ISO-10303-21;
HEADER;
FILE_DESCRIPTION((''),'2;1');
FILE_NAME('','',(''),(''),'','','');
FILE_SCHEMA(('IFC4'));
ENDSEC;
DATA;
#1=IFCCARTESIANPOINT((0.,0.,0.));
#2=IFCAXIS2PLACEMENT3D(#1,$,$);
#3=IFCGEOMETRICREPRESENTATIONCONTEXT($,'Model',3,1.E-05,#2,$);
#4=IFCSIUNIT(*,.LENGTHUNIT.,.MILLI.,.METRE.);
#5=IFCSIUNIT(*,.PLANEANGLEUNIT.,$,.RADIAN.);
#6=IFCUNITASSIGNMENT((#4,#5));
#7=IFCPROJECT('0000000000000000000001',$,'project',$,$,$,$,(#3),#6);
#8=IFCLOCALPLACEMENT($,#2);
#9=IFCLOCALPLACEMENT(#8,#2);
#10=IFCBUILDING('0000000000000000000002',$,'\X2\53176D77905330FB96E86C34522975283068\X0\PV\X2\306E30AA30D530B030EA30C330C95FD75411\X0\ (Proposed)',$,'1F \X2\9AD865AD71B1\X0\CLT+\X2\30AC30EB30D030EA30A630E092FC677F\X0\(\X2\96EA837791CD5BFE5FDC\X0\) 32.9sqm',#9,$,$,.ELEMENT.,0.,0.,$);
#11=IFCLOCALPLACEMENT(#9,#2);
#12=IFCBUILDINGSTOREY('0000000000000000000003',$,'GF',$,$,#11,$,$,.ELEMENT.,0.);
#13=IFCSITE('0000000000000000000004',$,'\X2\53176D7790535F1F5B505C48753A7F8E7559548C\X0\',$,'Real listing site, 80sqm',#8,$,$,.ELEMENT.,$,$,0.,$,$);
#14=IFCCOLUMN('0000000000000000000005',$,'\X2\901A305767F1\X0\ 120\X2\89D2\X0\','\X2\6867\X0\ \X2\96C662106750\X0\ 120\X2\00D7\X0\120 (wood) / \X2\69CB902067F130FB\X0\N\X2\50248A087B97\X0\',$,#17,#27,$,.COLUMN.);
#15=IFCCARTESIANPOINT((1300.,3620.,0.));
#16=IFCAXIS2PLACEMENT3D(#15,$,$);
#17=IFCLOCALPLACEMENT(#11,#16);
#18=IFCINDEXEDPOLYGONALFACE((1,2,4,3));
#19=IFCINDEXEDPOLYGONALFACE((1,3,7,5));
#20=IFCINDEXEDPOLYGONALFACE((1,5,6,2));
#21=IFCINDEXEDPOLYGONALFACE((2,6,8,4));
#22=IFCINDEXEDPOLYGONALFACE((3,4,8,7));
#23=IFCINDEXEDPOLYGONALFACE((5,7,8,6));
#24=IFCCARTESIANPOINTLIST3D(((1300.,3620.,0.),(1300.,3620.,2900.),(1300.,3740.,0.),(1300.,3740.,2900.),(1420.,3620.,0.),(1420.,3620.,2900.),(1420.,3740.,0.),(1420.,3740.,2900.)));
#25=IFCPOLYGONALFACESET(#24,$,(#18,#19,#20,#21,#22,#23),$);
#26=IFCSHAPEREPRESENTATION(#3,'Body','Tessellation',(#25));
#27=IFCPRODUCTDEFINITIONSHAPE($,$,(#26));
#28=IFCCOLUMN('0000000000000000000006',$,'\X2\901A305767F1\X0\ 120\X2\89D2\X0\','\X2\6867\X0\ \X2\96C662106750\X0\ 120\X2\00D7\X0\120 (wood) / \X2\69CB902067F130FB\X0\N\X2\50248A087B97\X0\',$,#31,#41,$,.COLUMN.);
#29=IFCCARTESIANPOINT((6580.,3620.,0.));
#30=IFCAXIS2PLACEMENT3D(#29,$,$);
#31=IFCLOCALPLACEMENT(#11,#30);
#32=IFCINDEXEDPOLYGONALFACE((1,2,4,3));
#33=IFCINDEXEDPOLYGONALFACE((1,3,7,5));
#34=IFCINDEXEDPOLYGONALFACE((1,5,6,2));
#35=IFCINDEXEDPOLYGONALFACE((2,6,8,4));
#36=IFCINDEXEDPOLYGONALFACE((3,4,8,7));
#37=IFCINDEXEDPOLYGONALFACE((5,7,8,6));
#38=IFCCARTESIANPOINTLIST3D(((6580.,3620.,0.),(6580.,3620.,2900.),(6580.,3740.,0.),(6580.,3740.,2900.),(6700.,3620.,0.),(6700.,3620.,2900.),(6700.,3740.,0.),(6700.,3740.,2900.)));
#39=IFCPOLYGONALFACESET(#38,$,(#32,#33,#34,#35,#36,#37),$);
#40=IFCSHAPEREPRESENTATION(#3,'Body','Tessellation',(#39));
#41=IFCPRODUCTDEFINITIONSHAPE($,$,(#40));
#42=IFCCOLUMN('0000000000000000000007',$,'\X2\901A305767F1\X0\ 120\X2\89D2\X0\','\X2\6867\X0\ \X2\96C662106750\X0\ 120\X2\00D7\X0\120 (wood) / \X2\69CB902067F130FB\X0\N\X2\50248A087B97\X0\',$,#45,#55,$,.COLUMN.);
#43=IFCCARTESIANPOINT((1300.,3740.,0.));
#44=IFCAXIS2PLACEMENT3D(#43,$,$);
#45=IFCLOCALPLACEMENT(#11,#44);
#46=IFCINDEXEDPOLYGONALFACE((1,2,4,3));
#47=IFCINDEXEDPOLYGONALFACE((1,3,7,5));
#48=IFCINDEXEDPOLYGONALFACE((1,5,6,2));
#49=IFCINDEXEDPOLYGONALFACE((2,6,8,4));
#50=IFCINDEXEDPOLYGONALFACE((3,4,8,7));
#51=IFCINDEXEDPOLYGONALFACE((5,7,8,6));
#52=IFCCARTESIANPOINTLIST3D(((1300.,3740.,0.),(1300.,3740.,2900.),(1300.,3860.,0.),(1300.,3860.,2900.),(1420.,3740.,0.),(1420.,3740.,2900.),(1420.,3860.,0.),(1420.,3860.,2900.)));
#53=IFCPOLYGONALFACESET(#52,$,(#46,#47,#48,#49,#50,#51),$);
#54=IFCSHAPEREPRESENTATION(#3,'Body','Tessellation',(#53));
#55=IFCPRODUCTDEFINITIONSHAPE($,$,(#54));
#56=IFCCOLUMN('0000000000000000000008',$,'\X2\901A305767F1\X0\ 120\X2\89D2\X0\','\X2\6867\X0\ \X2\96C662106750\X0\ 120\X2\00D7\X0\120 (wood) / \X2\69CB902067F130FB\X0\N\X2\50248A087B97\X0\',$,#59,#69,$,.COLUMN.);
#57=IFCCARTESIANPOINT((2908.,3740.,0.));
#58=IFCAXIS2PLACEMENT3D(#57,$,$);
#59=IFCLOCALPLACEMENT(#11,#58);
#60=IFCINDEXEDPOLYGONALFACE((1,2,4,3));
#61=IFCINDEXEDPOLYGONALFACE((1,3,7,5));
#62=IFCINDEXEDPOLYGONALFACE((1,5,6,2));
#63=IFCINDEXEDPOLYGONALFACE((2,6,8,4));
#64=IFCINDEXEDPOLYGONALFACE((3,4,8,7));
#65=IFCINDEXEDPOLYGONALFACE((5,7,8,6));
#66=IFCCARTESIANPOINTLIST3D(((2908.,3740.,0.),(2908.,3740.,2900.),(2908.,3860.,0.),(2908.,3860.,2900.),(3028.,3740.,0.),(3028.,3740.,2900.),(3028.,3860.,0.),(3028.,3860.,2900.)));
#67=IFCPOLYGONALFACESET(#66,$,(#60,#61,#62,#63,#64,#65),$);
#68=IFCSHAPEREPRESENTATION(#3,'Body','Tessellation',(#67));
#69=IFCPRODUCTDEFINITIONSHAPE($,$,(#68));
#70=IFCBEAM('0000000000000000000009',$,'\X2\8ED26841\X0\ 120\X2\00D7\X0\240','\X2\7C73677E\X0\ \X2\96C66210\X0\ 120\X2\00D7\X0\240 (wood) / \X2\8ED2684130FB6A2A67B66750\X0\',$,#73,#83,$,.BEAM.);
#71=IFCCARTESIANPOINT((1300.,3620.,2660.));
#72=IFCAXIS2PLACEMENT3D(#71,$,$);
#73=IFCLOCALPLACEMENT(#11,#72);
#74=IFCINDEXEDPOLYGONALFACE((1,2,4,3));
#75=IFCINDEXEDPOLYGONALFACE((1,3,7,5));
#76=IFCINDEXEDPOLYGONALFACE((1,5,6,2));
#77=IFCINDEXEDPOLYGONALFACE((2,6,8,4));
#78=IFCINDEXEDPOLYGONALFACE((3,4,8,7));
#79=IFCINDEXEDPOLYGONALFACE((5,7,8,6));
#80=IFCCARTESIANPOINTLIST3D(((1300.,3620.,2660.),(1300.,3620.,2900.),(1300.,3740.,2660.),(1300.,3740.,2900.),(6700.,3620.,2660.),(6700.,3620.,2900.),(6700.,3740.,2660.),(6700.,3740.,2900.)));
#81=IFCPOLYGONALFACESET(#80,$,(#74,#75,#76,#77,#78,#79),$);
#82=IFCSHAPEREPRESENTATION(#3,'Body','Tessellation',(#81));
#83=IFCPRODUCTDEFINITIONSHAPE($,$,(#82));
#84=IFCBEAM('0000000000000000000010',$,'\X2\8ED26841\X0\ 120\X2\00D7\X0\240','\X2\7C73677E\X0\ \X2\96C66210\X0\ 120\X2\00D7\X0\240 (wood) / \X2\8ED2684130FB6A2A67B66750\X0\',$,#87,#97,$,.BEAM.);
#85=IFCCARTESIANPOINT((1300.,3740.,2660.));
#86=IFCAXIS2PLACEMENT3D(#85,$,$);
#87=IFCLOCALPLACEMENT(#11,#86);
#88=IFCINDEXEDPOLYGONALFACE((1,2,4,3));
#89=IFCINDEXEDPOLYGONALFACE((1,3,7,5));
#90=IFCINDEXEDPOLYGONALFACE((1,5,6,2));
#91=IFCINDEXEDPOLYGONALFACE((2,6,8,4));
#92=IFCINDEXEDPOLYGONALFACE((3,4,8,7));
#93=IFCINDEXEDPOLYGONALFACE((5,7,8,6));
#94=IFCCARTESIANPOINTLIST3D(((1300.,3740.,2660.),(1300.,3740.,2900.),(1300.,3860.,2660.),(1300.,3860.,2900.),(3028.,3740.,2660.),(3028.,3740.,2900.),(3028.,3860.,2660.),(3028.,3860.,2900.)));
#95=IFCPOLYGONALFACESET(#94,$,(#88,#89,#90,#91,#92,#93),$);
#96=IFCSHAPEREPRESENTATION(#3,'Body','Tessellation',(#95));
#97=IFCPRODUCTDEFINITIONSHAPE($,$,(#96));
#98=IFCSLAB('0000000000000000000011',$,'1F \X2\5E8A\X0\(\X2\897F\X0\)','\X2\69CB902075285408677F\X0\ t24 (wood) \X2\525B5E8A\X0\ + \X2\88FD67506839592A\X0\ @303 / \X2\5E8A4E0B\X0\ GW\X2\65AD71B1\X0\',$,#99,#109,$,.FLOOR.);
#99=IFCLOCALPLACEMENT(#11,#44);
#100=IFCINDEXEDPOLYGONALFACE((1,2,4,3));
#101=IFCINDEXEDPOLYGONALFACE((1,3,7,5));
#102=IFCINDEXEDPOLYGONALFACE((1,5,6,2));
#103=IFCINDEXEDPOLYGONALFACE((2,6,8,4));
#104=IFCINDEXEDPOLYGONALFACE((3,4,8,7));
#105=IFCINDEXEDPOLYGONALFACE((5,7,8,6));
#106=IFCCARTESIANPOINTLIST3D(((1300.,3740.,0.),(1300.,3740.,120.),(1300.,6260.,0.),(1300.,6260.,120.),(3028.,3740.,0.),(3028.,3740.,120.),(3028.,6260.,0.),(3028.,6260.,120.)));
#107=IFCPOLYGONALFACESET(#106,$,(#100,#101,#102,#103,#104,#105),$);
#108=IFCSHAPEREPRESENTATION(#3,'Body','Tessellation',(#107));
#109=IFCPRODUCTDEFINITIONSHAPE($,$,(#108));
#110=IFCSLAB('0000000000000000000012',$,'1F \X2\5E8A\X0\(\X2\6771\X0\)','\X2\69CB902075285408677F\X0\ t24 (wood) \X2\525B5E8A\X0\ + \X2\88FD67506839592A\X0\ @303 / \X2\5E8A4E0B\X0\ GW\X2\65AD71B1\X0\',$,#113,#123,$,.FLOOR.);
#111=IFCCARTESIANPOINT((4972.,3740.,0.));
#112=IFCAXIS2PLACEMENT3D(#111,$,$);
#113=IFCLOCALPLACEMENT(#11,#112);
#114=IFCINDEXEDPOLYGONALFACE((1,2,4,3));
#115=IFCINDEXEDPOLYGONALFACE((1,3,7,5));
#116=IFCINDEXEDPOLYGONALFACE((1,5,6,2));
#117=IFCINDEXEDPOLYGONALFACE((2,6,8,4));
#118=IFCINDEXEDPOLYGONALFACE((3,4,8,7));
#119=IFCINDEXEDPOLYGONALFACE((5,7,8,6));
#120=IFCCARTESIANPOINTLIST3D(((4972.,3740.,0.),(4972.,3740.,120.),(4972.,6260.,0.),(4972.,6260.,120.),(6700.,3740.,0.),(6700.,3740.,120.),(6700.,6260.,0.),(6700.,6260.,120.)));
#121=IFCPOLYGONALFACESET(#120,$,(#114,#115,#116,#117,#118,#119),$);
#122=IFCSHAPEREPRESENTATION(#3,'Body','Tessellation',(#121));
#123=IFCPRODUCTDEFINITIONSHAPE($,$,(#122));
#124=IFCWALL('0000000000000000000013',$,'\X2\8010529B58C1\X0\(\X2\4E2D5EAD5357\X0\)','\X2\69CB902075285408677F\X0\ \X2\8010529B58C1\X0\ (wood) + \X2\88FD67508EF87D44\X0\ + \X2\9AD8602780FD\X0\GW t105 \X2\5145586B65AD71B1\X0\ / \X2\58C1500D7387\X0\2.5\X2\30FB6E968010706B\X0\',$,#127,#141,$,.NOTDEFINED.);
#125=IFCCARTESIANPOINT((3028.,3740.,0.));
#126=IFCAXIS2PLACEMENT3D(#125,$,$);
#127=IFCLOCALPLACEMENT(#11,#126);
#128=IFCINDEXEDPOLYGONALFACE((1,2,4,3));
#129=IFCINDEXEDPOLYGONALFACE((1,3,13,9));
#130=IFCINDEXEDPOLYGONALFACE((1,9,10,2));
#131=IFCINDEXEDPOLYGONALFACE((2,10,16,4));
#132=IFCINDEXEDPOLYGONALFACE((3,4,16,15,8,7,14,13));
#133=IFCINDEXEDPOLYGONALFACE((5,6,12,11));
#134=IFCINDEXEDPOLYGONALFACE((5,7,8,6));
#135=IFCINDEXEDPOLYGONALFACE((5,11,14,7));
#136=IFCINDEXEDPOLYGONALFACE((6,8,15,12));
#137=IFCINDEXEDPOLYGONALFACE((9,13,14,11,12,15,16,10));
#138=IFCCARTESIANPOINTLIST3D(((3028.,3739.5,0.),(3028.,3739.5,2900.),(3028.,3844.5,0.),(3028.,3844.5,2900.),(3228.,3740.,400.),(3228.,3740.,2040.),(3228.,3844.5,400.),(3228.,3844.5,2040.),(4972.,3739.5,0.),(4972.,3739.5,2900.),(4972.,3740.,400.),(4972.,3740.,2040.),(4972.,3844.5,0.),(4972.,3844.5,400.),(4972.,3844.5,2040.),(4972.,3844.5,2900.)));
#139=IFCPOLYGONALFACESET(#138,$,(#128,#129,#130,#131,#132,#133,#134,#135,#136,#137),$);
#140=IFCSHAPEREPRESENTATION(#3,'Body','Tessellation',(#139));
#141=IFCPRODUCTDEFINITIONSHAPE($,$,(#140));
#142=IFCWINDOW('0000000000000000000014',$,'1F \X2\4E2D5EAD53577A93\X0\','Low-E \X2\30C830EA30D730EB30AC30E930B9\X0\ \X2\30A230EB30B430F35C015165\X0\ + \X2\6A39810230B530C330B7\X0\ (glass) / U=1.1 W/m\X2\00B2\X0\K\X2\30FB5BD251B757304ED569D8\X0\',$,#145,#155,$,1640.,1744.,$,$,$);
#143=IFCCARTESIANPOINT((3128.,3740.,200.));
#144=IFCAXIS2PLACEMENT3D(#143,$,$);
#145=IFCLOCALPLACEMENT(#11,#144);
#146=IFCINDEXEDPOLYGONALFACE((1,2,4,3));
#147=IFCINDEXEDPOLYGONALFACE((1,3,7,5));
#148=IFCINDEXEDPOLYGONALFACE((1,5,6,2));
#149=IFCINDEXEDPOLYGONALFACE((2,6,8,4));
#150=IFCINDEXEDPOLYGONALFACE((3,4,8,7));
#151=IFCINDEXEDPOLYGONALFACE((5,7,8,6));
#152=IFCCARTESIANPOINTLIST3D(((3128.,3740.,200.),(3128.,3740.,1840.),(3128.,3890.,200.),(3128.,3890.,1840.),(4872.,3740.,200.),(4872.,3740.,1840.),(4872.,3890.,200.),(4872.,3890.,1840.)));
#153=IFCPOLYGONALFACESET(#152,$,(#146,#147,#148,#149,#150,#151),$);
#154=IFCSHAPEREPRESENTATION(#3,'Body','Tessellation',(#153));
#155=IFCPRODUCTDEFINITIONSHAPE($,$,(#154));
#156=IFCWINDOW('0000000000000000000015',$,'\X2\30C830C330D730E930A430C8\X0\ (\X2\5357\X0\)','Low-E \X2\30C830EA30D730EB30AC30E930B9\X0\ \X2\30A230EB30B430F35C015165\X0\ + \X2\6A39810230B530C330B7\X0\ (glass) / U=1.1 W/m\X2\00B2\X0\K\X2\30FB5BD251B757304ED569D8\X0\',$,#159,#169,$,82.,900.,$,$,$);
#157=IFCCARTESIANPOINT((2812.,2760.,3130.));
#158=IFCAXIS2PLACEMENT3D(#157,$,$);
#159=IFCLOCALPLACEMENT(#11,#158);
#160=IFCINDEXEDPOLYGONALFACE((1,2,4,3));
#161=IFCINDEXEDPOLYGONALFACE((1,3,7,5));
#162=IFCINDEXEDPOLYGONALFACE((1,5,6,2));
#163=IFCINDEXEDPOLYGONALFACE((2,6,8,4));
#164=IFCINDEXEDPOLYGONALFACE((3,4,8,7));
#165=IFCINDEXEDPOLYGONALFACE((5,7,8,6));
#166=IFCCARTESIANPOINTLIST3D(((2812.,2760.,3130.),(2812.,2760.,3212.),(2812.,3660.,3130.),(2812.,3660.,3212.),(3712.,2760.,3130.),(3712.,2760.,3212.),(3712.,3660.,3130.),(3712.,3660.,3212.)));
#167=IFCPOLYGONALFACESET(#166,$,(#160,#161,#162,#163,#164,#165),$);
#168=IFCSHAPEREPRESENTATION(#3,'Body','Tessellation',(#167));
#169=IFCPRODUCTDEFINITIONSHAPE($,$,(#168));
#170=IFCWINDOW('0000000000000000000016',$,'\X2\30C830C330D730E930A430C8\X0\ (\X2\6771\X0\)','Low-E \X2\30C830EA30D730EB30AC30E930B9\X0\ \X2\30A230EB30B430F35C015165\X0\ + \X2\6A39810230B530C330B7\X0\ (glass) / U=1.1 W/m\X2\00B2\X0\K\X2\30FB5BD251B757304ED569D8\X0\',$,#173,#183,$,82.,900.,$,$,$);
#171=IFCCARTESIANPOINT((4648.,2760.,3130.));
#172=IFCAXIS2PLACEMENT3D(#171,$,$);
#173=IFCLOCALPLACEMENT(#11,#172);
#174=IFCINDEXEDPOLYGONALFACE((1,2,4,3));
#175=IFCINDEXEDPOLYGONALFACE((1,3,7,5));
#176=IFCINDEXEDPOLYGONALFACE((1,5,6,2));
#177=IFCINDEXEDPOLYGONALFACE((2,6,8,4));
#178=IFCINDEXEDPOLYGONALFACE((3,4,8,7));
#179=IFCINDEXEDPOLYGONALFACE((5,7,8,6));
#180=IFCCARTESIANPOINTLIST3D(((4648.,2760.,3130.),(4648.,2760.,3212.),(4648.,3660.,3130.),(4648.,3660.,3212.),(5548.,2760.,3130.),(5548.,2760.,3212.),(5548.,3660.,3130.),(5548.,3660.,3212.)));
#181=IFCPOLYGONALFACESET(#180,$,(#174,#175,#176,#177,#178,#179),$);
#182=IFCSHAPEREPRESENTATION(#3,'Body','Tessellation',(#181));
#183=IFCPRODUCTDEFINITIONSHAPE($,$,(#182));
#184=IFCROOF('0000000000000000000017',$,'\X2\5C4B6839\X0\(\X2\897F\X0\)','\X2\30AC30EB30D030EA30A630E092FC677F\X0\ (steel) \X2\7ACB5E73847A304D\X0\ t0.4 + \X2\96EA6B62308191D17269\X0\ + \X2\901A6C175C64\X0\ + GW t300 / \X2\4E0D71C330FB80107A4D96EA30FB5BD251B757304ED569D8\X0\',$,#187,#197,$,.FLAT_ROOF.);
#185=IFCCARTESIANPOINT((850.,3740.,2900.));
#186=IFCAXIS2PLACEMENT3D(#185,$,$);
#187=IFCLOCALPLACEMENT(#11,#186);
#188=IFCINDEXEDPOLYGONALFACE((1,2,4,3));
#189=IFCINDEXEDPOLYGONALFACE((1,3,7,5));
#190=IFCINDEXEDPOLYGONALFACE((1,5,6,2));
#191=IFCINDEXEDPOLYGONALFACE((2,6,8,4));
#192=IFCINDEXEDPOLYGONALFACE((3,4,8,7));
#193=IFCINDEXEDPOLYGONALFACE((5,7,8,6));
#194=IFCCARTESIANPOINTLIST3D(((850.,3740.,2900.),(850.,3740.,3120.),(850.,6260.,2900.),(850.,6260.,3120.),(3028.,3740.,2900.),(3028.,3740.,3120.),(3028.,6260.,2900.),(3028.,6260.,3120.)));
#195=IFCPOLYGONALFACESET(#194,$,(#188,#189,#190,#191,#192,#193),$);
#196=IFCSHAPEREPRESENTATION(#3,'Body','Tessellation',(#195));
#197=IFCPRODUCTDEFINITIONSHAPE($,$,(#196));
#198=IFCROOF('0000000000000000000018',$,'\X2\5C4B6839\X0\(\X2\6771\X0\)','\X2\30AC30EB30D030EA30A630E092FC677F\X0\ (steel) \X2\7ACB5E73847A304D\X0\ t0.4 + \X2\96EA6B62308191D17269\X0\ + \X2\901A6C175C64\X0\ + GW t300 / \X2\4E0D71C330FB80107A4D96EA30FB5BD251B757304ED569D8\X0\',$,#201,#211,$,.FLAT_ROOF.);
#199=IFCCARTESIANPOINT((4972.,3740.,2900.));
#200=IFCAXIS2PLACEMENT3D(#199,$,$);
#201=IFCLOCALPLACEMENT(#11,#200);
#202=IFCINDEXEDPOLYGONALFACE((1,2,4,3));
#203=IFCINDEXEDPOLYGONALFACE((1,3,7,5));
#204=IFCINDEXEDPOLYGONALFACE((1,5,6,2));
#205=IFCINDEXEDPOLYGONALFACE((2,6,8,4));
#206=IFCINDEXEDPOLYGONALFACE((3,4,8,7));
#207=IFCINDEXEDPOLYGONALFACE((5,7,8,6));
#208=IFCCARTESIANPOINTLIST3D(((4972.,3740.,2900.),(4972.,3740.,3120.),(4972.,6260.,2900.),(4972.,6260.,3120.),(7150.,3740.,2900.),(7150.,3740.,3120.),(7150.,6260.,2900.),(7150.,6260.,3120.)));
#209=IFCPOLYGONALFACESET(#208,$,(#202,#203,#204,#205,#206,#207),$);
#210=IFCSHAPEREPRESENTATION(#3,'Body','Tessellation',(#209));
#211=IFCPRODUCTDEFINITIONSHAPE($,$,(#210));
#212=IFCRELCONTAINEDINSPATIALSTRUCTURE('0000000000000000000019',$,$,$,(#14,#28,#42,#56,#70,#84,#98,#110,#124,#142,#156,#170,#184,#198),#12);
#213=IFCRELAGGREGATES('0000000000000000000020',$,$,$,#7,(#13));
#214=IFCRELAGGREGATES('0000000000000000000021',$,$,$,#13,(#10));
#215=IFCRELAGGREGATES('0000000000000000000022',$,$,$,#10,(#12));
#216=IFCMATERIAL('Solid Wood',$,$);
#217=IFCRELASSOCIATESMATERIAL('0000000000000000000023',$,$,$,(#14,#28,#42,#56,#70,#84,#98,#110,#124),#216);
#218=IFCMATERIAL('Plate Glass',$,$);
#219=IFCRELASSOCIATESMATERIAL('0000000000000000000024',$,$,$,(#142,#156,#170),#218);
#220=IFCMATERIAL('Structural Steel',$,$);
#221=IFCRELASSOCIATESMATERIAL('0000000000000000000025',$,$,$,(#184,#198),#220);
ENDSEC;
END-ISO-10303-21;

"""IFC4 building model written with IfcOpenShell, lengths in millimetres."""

from ifc_helpers import new_model, si_unit, frame, frame_2d, origin, place, context, project, spatial, rectangle, extrude, material, element, fill, save


model = new_model("IFC4")

# Units and contexts
model_context = context("Model", 3, precision=1e-05, world=origin())
ifc_project = project(units=[si_unit("LENGTHUNIT", "METRE", prefix="MILLI"), si_unit("PLANEANGLEUNIT", "RADIAN")], contexts=[model_context])

# Site, building, storey
site_placement = place(None, origin())
site = spatial("IfcSite", under=ifc_project, at=site_placement, Name="北海道弟子屈町美留和", ObjectType="Real listing site, 80sqm", CompositionType="ELEMENT", RefElevation=0.0)
building_placement = place(site_placement, origin())
building = spatial("IfcBuilding", under=site, at=building_placement, Name="北海道・雨水利用とPVのオフグリッド志向 (Proposed)", ObjectType="1F 高断熱CLT+ガルバリウム鋼板(雪荷重対応) 32.9sqm", CompositionType="ELEMENT", ElevationOfRefHeight=0.0, ElevationOfTerrain=0.0)
storey_placement = place(building_placement, origin())
storey = spatial("IfcBuildingStorey", under=building, at=storey_placement, Name="GF", CompositionType="ELEMENT", Elevation=0.0)

# Columns
ifc_material_1 = material(Name="Solid Wood")
column_1_placement = place(storey_placement, frame((1300.0, 3620.0, 0.0)))
element("IfcColumn", 1, at=column_1_placement, inside=storey, material=ifc_material_1, Name="通し柱 120角", Description="桧 集成材 120×120 (wood) / 構造柱・N値計算", PredefinedType="COLUMN", context=model_context, shape_type="SweptSolid", body=[
    extrude(rectangle(XDim=120.0, YDim=120.0, at=frame_2d((60.0, 60.0))), frame((1300.0, 3620.0, 0.0)), (0.0, 0.0, 1.0), 2900.0),
])
column_2_placement = place(storey_placement, frame((6580.0, 3620.0, 0.0)))
element("IfcColumn", 2, at=column_2_placement, inside=storey, material=ifc_material_1, Name="通し柱 120角", Description="桧 集成材 120×120 (wood) / 構造柱・N値計算", PredefinedType="COLUMN", context=model_context, shape_type="SweptSolid", body=[
    extrude(rectangle(XDim=120.0, YDim=120.0, at=frame_2d((60.0, 60.0))), frame((6580.0, 3620.0, 0.0)), (0.0, 0.0, 1.0), 2900.0),
])
column_3_placement = place(storey_placement, frame((1300.0, 3740.0, 0.0)))
element("IfcColumn", 3, at=column_3_placement, inside=storey, material=ifc_material_1, Name="通し柱 120角", Description="桧 集成材 120×120 (wood) / 構造柱・N値計算", PredefinedType="COLUMN", context=model_context, shape_type="SweptSolid", body=[
    extrude(rectangle(XDim=120.0, YDim=120.0, at=frame_2d((60.0, 60.0))), frame((1300.0, 3740.0, 0.0)), (0.0, 0.0, 1.0), 2900.0),
])
column_4_placement = place(storey_placement, frame((2908.0, 3740.0, 0.0)))
element("IfcColumn", 4, at=column_4_placement, inside=storey, material=ifc_material_1, Name="通し柱 120角", Description="桧 集成材 120×120 (wood) / 構造柱・N値計算", PredefinedType="COLUMN", context=model_context, shape_type="SweptSolid", body=[
    extrude(rectangle(XDim=120.0, YDim=120.0, at=frame_2d((60.0, 60.0))), frame((2908.0, 3740.0, 0.0)), (0.0, 0.0, 1.0), 2900.0),
])

# Beams
beam_1_placement = place(storey_placement, frame((1300.0, 3620.0, 2660.0)))
element("IfcBeam", 5, at=beam_1_placement, inside=storey, material=ifc_material_1, Name="軒桁 120×240", Description="米松 集成 120×240 (wood) / 軒桁・横架材", PredefinedType="BEAM", context=model_context, shape_type="SweptSolid", body=[
    extrude(rectangle(XDim=5400.0, YDim=120.0, at=frame_2d((2700.0, 60.0))), frame((1300.0, 3620.0, 2660.0)), (0.0, 0.0, 1.0), 240.0),
])
beam_2_placement = place(storey_placement, frame((1300.0, 3740.0, 2660.0)))
element("IfcBeam", 6, at=beam_2_placement, inside=storey, material=ifc_material_1, Name="軒桁 120×240", Description="米松 集成 120×240 (wood) / 軒桁・横架材", PredefinedType="BEAM", context=model_context, shape_type="SweptSolid", body=[
    extrude(rectangle(XDim=1728.0, YDim=120.0, at=frame_2d((864.0, 60.0))), frame((1300.0, 3740.0, 2660.0)), (0.0, 0.0, 1.0), 240.0),
])

# Slabs
slab_1_placement = place(storey_placement, frame((1300.0, 3740.0, 0.0)))
element("IfcSlab", 7, at=slab_1_placement, inside=storey, material=ifc_material_1, Name="1F 床(西)", Description="構造用合板 t24 (wood) 剛床 + 製材根太 @303 / 床下 GW断熱", PredefinedType="FLOOR", context=model_context, shape_type="SweptSolid", body=[
    extrude(rectangle(XDim=1728.0, YDim=2520.0, at=frame_2d((864.0, 1260.0))), frame((1300.0, 3740.0, 0.0)), (0.0, 0.0, 1.0), 120.0),
])
slab_2_placement = place(storey_placement, frame((4972.0, 3740.0, 0.0)))
element("IfcSlab", 8, at=slab_2_placement, inside=storey, material=ifc_material_1, Name="1F 床(東)", Description="構造用合板 t24 (wood) 剛床 + 製材根太 @303 / 床下 GW断熱", PredefinedType="FLOOR", context=model_context, shape_type="SweptSolid", body=[
    extrude(rectangle(XDim=1728.0, YDim=2520.0, at=frame_2d((864.0, 1260.0))), frame((4972.0, 3740.0, 0.0)), (0.0, 0.0, 1.0), 120.0),
])

# Wall, opening, window
wall_1_placement = place(storey_placement, frame((3028.0, 3740.0, 0.0)))
wall_1 = element("IfcWall", 9, at=wall_1_placement, inside=storey, material=ifc_material_1, Name="耐力壁(中庭南)", Description="構造用合板 耐力壁 (wood) + 製材軸組 + 高性能GW t105 充填断熱 / 壁倍率2.5・準耐火", PredefinedType="NOTDEFINED", context=model_context, shape_type="SweptSolid", body=[
    extrude(rectangle(XDim=1944.0, YDim=105.0, at=frame_2d((972.0, 52.0))), frame((3028.0, 3740.0, 0.0)), (0.0, 0.0, 1.0), 2900.0),
])
opening_placement = place(storey_placement, frame((3128.0, 3740.0, 200.0)))
opening = element("IfcOpeningElement", 10, at=opening_placement, cuts=wall_1, PredefinedType="NOTDEFINED", context=model_context, shape_type="SweptSolid", body=[
    extrude(rectangle(XDim=1744.0, YDim=150.0, at=frame_2d((872.0, 75.0))), frame((3128.0, 3740.0, 200.0)), (0.0, 0.0, 1.0), 1640.0),
])
ifc_material_2 = material(Name="Plate Glass")
window_1_placement = place(storey_placement, frame((3128.0, 3740.0, 200.0)))
window_1 = element("IfcWindow", 11, at=window_1_placement, inside=storey, material=ifc_material_2, Name="1F 中庭南窓", Description="Low-E トリプルガラス アルゴン封入 + 樹脂サッシ (glass) / U=1.1 W/m²K・寒冷地仕様", OverallHeight=1640.0, OverallWidth=1744.0, context=model_context, shape_type="SweptSolid", body=[
    extrude(rectangle(XDim=1744.0, YDim=150.0, at=frame_2d((872.0, 75.0))), frame((3128.0, 3740.0, 200.0)), (0.0, 0.0, 1.0), 1640.0),
])
fill(opening, window_1)

# Windows
window_2_placement = place(storey_placement, frame((2812.0, 2760.0, 3130.0)))
element("IfcWindow", 12, at=window_2_placement, inside=storey, material=ifc_material_2, Name="トップライト (南)", Description="Low-E トリプルガラス アルゴン封入 + 樹脂サッシ (glass) / U=1.1 W/m²K・寒冷地仕様", OverallHeight=82.0, OverallWidth=900.0, context=model_context, shape_type="SweptSolid", body=[
    extrude(rectangle(XDim=900.0, YDim=900.0, at=frame_2d((450.0, 450.0))), frame((2812.0, 2760.0, 3130.0)), (0.0, 0.0, 1.0), 82.0),
])
window_3_placement = place(storey_placement, frame((4648.0, 2760.0, 3130.0)))
element("IfcWindow", 13, at=window_3_placement, inside=storey, material=ifc_material_2, Name="トップライト (東)", Description="Low-E トリプルガラス アルゴン封入 + 樹脂サッシ (glass) / U=1.1 W/m²K・寒冷地仕様", OverallHeight=82.0, OverallWidth=900.0, context=model_context, shape_type="SweptSolid", body=[
    extrude(rectangle(XDim=900.0, YDim=900.0, at=frame_2d((450.0, 450.0))), frame((4648.0, 2760.0, 3130.0)), (0.0, 0.0, 1.0), 82.0),
])

# Roofs
ifc_material_3 = material(Name="Structural Steel")
roof_1_placement = place(storey_placement, frame((850.0, 3740.0, 2900.0)))
element("IfcRoof", 14, at=roof_1_placement, inside=storey, material=ifc_material_3, Name="屋根(西)", Description="ガルバリウム鋼板 (steel) 立平葺き t0.4 + 雪止め金物 + 通気層 + GW t300 / 不燃・耐積雪・寒冷地仕様", PredefinedType="FLAT_ROOF", context=model_context, shape_type="SweptSolid", body=[
    extrude(rectangle(XDim=2178.0, YDim=2520.0, at=frame_2d((1089.0, 1260.0))), frame((850.0, 3740.0, 2900.0)), (0.0, 0.0, 1.0), 220.0),
])
roof_2_placement = place(storey_placement, frame((4972.0, 3740.0, 2900.0)))
element("IfcRoof", 15, at=roof_2_placement, inside=storey, material=ifc_material_3, Name="屋根(東)", Description="ガルバリウム鋼板 (steel) 立平葺き t0.4 + 雪止め金物 + 通気層 + GW t300 / 不燃・耐積雪・寒冷地仕様", PredefinedType="FLAT_ROOF", context=model_context, shape_type="SweptSolid", body=[
    extrude(rectangle(XDim=2178.0, YDim=2520.0, at=frame_2d((1089.0, 1260.0))), frame((4972.0, 3740.0, 2900.0)), (0.0, 0.0, 1.0), 220.0),
])

save(model, "model.ifc")
